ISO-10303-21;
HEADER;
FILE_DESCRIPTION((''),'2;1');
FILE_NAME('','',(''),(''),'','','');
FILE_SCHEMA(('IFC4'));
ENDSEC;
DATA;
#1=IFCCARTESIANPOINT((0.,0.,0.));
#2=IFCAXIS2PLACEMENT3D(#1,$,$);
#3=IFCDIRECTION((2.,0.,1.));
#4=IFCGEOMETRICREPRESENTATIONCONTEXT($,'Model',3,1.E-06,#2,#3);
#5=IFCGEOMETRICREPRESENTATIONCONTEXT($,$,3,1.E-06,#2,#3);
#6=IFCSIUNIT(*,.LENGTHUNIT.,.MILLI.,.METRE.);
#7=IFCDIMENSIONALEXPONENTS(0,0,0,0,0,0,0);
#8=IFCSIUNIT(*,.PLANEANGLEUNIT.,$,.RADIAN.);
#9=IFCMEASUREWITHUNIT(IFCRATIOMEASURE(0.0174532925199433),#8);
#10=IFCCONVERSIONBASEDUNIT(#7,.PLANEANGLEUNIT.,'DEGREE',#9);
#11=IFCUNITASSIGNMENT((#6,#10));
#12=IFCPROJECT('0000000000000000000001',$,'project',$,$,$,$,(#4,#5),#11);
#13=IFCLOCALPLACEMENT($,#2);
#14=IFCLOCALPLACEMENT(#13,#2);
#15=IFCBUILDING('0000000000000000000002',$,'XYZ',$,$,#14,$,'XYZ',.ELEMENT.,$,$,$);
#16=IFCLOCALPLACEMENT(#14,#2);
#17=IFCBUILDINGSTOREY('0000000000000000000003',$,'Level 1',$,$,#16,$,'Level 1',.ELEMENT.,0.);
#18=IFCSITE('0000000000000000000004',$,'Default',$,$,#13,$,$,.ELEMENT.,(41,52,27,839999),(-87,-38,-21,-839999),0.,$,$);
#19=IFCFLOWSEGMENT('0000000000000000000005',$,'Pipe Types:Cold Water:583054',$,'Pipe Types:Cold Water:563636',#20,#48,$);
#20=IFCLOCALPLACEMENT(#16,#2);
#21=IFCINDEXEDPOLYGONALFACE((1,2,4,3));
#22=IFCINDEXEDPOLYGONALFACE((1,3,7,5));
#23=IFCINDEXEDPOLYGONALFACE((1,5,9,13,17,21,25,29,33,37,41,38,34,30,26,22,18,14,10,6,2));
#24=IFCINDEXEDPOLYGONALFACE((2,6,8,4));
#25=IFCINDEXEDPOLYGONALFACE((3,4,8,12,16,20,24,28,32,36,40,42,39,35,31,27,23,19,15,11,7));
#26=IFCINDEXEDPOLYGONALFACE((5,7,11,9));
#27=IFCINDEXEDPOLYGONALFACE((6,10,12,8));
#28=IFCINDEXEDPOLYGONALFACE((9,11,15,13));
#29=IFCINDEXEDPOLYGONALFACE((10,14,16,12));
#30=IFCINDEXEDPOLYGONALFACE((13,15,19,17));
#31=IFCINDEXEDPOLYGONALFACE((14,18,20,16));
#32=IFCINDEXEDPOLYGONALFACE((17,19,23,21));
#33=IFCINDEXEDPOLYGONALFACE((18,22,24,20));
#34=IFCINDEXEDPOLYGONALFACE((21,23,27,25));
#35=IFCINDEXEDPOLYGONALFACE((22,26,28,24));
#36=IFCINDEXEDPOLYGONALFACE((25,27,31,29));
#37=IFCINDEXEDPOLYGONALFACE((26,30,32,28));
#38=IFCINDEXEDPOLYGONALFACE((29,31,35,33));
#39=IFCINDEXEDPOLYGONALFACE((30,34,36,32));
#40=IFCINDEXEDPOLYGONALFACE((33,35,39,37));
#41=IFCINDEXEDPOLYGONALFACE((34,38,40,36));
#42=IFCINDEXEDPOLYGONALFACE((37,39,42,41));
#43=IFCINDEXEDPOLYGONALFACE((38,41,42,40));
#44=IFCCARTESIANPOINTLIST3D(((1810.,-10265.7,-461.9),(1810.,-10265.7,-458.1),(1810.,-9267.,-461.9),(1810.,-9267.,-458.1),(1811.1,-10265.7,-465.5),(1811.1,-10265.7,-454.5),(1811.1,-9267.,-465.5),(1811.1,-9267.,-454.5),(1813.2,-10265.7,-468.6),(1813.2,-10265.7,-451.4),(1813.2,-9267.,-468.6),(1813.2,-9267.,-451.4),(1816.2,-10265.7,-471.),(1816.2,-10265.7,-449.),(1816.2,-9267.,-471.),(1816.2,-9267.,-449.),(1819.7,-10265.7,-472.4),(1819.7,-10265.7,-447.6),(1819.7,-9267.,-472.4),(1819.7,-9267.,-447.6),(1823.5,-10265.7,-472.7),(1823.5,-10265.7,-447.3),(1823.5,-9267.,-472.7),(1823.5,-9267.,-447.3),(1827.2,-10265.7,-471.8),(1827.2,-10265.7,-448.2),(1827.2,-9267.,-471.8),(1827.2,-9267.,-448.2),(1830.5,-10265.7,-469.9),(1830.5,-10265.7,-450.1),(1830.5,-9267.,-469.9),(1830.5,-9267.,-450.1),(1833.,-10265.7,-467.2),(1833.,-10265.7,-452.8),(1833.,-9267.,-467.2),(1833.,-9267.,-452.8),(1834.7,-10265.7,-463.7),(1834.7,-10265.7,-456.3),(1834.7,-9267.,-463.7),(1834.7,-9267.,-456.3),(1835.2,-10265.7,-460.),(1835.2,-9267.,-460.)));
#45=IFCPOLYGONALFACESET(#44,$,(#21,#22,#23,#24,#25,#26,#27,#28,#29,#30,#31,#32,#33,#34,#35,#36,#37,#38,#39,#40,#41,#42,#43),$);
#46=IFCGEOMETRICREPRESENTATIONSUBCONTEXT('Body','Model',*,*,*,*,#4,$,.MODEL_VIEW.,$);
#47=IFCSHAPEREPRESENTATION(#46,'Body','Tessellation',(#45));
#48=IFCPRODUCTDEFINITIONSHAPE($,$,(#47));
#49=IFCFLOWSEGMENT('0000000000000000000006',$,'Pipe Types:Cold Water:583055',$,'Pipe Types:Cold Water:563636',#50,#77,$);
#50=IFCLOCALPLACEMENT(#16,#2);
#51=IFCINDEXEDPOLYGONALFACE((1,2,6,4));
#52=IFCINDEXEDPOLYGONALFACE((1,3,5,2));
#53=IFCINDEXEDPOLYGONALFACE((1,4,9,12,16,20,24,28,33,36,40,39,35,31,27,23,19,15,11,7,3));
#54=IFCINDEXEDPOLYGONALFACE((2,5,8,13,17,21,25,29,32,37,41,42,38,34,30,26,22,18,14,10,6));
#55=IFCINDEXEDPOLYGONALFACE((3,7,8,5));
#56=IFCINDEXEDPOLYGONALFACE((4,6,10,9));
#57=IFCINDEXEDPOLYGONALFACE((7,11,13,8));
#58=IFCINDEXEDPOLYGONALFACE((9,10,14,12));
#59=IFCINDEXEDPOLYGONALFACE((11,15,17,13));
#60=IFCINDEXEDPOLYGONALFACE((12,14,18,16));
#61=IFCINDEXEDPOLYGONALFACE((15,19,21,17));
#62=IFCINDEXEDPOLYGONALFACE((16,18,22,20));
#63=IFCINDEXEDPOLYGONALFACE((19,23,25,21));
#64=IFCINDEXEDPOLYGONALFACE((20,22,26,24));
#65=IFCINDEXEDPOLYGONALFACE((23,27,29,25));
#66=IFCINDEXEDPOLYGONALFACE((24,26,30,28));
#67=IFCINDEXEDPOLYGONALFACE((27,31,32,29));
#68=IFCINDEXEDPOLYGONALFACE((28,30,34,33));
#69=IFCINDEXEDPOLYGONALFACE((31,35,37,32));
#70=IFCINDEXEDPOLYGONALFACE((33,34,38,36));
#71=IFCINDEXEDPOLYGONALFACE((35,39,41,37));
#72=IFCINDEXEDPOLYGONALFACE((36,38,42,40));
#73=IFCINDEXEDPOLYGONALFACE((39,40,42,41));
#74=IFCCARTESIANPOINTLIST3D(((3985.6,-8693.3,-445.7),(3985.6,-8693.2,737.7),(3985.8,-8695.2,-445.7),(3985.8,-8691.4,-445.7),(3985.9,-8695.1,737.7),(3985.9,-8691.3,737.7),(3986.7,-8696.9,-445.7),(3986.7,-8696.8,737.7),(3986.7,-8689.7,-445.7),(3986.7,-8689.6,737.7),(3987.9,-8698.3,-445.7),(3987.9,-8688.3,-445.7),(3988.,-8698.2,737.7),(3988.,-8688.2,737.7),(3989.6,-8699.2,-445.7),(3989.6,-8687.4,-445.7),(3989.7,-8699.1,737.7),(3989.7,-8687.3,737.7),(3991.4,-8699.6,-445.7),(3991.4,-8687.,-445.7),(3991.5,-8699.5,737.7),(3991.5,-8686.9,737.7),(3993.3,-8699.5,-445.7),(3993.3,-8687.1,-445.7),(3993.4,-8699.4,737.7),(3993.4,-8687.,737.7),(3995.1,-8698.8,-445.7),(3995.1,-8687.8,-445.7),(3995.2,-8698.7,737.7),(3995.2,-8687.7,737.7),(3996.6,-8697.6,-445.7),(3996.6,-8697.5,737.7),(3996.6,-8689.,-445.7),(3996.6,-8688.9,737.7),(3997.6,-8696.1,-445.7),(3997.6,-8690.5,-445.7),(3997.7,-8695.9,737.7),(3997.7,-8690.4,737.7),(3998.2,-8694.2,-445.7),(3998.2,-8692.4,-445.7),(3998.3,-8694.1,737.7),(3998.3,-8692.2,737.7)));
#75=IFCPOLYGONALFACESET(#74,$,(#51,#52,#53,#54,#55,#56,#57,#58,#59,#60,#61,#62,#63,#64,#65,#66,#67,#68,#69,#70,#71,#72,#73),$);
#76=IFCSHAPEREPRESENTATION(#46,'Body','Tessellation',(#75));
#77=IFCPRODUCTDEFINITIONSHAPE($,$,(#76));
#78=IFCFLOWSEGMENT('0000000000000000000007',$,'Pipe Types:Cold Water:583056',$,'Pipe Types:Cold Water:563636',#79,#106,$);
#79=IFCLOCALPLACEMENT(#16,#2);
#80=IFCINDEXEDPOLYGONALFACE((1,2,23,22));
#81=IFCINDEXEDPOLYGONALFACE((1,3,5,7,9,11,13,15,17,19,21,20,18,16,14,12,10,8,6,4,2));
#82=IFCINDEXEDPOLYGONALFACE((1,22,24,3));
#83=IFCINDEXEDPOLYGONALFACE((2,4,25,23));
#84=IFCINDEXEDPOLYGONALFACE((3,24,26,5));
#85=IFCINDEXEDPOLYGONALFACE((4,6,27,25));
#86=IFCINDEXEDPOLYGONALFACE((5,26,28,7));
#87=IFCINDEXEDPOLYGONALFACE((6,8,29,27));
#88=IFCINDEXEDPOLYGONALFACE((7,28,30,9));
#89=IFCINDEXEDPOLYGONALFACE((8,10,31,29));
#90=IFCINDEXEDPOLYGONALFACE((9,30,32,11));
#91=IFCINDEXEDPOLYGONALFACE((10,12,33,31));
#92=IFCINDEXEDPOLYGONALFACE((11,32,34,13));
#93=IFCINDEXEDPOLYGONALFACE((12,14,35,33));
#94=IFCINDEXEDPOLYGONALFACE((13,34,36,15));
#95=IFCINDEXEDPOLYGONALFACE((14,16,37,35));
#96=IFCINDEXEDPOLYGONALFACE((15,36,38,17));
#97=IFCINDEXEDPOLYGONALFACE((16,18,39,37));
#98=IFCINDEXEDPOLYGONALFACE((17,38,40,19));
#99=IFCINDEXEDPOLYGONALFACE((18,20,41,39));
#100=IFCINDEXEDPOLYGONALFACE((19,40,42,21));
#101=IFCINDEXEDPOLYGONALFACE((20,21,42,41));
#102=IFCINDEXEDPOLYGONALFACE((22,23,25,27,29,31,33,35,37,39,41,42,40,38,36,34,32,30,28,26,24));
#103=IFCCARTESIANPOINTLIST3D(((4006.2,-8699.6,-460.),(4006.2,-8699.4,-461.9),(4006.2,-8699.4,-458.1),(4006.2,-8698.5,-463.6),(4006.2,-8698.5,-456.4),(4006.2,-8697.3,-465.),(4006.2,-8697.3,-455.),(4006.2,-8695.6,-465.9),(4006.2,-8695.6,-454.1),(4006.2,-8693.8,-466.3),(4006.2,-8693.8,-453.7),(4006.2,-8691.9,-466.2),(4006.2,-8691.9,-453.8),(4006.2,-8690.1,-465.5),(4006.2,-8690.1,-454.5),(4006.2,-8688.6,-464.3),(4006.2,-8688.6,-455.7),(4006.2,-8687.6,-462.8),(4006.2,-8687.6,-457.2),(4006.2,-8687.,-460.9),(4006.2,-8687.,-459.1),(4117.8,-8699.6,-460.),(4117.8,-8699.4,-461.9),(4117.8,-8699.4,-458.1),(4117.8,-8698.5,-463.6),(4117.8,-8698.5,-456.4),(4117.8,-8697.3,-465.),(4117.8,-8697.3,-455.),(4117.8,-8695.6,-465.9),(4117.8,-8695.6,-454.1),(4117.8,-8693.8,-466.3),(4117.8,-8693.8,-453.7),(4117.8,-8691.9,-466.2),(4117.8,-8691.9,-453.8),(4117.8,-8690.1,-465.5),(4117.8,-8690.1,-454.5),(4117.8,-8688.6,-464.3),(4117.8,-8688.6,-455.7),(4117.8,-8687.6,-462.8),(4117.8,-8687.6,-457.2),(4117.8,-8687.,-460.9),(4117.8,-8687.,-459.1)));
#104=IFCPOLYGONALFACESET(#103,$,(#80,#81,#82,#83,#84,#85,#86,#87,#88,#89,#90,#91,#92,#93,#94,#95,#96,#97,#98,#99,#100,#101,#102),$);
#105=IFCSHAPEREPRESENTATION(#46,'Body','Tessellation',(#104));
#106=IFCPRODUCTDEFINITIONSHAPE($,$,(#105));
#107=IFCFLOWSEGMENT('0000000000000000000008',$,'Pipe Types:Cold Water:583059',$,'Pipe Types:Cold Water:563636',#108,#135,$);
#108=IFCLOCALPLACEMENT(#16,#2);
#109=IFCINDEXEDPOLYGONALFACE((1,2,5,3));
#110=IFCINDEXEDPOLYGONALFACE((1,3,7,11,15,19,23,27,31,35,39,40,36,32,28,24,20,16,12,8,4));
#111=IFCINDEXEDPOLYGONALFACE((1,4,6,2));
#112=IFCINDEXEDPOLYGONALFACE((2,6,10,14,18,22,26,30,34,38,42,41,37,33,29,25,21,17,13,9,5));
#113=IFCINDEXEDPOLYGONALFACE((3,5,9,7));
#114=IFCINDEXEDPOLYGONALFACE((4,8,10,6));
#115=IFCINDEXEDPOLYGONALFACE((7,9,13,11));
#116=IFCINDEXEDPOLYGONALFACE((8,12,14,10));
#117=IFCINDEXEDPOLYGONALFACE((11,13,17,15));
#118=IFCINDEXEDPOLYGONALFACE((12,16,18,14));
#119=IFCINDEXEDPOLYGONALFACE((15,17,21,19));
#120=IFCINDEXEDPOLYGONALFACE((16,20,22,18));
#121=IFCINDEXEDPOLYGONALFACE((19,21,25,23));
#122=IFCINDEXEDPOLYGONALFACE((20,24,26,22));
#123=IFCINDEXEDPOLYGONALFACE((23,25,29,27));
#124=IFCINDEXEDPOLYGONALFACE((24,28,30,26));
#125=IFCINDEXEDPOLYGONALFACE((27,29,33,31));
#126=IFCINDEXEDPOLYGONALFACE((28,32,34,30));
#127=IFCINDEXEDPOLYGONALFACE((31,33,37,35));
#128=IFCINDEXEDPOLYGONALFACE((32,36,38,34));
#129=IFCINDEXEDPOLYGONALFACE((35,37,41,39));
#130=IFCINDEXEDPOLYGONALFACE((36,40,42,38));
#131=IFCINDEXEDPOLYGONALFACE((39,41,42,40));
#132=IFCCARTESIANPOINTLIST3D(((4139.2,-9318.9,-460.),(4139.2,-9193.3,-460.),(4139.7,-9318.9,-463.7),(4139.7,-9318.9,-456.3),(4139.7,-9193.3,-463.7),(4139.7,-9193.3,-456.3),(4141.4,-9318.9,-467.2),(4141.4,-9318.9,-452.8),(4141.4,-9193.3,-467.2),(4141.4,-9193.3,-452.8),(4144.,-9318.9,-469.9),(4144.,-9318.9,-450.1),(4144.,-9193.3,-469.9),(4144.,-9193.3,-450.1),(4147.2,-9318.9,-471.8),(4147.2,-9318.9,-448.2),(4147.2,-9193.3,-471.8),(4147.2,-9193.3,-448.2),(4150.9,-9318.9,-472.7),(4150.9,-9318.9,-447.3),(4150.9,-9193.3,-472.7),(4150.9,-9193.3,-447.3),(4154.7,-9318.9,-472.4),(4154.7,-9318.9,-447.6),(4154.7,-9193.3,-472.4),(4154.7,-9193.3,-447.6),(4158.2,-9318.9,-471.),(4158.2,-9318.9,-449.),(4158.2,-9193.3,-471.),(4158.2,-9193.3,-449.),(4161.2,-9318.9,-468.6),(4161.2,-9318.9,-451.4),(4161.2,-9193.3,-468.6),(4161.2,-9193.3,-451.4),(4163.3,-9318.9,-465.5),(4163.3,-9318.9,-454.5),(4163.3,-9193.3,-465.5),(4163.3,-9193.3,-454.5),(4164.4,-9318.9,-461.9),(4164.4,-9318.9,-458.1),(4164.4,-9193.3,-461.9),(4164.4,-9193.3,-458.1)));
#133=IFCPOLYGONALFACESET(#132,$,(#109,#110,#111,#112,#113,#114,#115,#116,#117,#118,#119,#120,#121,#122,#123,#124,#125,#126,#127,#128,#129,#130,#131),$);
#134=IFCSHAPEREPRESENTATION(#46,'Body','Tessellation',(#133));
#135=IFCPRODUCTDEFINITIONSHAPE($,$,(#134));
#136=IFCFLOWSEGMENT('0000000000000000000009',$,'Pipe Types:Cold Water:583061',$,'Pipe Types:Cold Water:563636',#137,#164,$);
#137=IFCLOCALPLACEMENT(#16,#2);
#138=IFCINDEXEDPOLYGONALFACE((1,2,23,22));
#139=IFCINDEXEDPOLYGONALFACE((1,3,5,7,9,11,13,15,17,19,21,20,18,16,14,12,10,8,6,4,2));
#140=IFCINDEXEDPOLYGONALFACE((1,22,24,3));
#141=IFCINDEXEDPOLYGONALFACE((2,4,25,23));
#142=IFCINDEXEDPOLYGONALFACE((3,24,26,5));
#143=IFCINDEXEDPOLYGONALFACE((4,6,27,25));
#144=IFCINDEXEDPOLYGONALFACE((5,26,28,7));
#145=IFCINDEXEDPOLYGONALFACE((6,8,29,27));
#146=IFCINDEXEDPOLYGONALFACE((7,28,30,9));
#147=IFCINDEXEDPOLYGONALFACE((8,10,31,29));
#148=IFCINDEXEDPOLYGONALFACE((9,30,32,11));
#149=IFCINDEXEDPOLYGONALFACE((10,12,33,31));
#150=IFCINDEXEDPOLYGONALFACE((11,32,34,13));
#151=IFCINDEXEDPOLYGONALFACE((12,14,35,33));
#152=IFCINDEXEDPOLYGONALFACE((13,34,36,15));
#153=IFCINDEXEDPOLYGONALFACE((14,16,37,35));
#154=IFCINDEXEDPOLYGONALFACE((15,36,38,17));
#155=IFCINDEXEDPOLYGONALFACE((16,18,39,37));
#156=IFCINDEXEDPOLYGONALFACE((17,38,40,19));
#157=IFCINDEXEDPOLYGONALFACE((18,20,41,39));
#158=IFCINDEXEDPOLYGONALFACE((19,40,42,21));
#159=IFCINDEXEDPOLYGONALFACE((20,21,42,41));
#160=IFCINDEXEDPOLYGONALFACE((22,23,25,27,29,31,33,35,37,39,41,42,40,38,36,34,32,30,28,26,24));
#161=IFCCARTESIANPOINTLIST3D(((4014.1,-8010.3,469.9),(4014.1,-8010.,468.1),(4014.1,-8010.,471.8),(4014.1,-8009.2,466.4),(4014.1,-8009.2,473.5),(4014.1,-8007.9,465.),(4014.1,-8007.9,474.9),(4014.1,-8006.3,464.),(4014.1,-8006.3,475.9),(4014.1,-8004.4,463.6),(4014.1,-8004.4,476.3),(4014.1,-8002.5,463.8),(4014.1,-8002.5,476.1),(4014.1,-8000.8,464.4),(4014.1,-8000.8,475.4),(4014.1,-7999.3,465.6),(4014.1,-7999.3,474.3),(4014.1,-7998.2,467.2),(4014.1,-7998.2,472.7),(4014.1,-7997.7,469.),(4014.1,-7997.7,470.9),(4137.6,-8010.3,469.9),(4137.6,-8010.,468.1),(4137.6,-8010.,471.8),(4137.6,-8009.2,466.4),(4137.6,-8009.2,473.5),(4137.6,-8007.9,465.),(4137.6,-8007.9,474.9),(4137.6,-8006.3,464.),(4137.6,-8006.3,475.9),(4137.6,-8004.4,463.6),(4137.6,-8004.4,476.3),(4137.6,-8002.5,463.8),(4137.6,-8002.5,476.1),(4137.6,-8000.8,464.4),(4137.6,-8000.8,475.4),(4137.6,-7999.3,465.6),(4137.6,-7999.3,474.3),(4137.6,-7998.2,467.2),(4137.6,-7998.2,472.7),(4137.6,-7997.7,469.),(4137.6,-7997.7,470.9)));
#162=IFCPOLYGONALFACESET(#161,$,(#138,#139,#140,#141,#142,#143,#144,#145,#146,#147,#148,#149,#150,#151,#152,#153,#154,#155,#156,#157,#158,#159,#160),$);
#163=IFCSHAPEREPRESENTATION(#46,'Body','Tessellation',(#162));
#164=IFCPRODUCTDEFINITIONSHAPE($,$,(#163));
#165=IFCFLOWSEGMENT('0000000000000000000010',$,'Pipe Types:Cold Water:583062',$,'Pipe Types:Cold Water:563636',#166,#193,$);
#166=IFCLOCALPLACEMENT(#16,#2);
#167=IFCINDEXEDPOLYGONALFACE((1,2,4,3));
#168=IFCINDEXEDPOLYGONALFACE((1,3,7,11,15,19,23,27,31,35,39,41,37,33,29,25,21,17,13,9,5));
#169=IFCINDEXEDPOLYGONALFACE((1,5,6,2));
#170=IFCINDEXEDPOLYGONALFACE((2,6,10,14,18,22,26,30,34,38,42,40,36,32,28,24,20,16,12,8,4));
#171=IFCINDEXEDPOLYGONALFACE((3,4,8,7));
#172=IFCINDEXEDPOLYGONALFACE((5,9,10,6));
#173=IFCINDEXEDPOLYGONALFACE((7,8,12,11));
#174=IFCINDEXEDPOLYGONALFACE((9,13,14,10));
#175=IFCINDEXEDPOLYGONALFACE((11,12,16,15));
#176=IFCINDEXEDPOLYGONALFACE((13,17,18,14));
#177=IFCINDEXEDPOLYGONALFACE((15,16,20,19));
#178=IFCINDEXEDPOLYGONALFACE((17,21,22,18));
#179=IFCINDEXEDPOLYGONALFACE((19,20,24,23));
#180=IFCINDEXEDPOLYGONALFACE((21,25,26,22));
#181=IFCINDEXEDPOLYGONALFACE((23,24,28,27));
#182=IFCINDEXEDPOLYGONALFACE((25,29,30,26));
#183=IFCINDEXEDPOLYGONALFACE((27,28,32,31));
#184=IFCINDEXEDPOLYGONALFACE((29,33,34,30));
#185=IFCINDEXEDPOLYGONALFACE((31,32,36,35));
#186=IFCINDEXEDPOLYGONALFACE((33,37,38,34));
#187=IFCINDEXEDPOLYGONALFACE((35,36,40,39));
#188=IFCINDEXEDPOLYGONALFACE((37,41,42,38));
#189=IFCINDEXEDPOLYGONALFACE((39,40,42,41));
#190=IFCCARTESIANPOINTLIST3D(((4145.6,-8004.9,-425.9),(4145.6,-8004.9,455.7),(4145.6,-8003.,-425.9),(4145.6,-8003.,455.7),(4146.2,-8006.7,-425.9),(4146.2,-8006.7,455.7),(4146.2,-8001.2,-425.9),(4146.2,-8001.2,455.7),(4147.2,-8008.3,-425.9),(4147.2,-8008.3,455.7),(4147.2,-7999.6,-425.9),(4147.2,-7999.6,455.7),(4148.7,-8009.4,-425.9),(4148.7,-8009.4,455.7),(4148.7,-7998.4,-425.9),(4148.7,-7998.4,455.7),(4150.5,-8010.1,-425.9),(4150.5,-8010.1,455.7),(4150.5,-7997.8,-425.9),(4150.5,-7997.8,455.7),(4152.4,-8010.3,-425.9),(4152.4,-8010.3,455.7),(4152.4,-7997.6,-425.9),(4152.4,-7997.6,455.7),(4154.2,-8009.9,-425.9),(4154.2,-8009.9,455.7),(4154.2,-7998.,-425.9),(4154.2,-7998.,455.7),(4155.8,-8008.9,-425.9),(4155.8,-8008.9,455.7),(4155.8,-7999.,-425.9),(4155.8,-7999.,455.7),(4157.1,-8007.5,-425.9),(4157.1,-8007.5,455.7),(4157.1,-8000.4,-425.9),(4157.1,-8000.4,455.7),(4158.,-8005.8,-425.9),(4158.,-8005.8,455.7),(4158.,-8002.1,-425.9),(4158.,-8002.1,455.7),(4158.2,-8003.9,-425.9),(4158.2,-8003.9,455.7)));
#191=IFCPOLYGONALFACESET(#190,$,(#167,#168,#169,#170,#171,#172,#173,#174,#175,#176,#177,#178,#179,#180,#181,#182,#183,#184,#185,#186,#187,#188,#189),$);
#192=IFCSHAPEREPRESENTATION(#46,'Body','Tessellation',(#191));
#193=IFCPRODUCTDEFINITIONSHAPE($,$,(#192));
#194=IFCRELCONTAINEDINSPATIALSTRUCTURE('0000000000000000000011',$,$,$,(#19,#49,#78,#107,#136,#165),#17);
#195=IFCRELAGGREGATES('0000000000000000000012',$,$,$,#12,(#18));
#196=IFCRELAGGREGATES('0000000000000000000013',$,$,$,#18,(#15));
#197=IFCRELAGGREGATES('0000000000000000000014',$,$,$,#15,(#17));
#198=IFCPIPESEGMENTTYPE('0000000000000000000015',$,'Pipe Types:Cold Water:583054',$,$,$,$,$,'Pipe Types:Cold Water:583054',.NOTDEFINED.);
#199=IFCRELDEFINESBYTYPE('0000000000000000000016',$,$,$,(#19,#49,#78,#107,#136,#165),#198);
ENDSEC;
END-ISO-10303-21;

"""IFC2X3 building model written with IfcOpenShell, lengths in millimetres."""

from ifc_helpers import new_model, entity, si_unit, converted_unit, direction, frame, frame_2d, origin, origin_2d_with_axis, place, context, subcontext, project, spatial, circle, extrude, type_object, element, save


model = new_model("IFC2X3")

# Units and contexts
model_context = context("Model", 3, precision=1e-06, world=origin(), true_north=direction((2.0, 0.0, 1.0)))
context_of_model = context(None, 3, precision=1e-06, world=origin(), true_north=direction((2.0, 0.0, 1.0)))
body_context = subcontext(model_context, "Body", "Model", "MODEL_VIEW")
ifc_project = project(units=[si_unit("LENGTHUNIT", "METRE", prefix="MILLI"), converted_unit("PLANEANGLEUNIT", "DEGREE", entity("IfcRatioMeasure", 0.0174532925199433), si_unit("PLANEANGLEUNIT", "RADIAN"), dimensions=[0, 0, 0, 0, 0, 0, 0])], contexts=[model_context, context_of_model])

# Site, building, storey
site_placement = place(None, origin())
site = spatial("IfcSite", under=ifc_project, at=site_placement, Name="Default", CompositionType="ELEMENT", RefLatitude=(41, 52, 27, 839999), RefLongitude=(-87, -38, -21, -839999), RefElevation=0.0)
building_placement = place(site_placement, origin())
building = spatial("IfcBuilding", under=site, at=building_placement, Name="XYZ", LongName="XYZ", CompositionType="ELEMENT")
storey_placement = place(building_placement, origin())
storey = spatial("IfcBuildingStorey", under=building, at=storey_placement, Name="Level 1", LongName="Level 1", CompositionType="ELEMENT", Elevation=0.0)

# Flow segments
pipe_segment_type_1 = type_object("IfcPipeSegmentType", Name="Pipe Types:Cold Water:583054", ElementType="Pipe Types:Cold Water:583054", PredefinedType="NOTDEFINED")
flow_segment_1_placement = place(storey_placement, origin())
element("IfcFlowSegment", 1, at=flow_segment_1_placement, inside=storey, type_object=pipe_segment_type_1, Name="Pipe Types:Cold Water:583054", ObjectType="Pipe Types:Cold Water:563636", context=body_context, shape_type="SweptSolid", body=[
    extrude(circle(Radius=12.7, at=origin_2d_with_axis()), frame((1822.5, -10265.7, -460.0), z_axis=(0.0, 1.0, 0.0), x_axis=(1.0, 0.0, 0.0)), (0.0, 0.0, 1.0), 998.7),
])
flow_segment_2_placement = place(storey_placement, origin())
element("IfcFlowSegment", 2, at=flow_segment_2_placement, inside=storey, type_object=pipe_segment_type_1, Name="Pipe Types:Cold Water:583055", ObjectType="Pipe Types:Cold Water:563636", context=body_context, shape_type="SweptSolid", body=[
    extrude(circle(Radius=6.3, at=frame_2d((0.0, 0.0), x_axis=(1.0, 0.0))), frame((3991.9, -8693.3, -445.7), z_axis=(0.000073, 0.000088, 1.0), x_axis=(-1.0, 0.0, 0.000073)), (0.0, 0.0, 1.0), 1183.4),
])
flow_segment_3_placement = place(storey_placement, origin())
element("IfcFlowSegment", 3, at=flow_segment_3_placement, inside=storey, type_object=pipe_segment_type_1, Name="Pipe Types:Cold Water:583056", ObjectType="Pipe Types:Cold Water:563636", context=body_context, shape_type="SweptSolid", body=[
    extrude(circle(Radius=6.3, at=origin_2d_with_axis()), frame((4006.2, -8693.3, -460.0), z_axis=(1.0, 0.0, 0.0), x_axis=(0.0, -1.0, 0.0)), (0.0, 0.0, 1.0), 111.6),
])
flow_segment_4_placement = place(storey_placement, origin())
element("IfcFlowSegment", 4, at=flow_segment_4_placement, inside=storey, type_object=pipe_segment_type_1, Name="Pipe Types:Cold Water:583059", ObjectType="Pipe Types:Cold Water:563636", context=body_context, shape_type="SweptSolid", body=[
    extrude(circle(Radius=12.7, at=frame_2d((0.0, 0.0), x_axis=(1.0, 0.0))), frame((4151.9, -9318.9, -460.0), z_axis=(0.0, 1.0, 0.0), x_axis=(-1.0, 0.0, 0.0)), (0.0, 0.0, 1.0), 125.5),
])
flow_segment_5_placement = place(storey_placement, origin())
element("IfcFlowSegment", 5, at=flow_segment_5_placement, inside=storey, type_object=pipe_segment_type_1, Name="Pipe Types:Cold Water:583061", ObjectType="Pipe Types:Cold Water:563636", context=body_context, shape_type="SweptSolid", body=[
    extrude(circle(Radius=6.3, at=frame_2d((0.0, 0.0), x_axis=(1.0, 0.0))), frame((4014.1, -8003.9, 469.9), z_axis=(1.0, 0.0, 0.0), x_axis=(0.0, -1.0, 0.0)), (0.0, 0.0, 1.0), 123.5),
])
flow_segment_6_placement = place(storey_placement, origin())
element("IfcFlowSegment", 6, at=flow_segment_6_placement, inside=storey, type_object=pipe_segment_type_1, Name="Pipe Types:Cold Water:583062", ObjectType="Pipe Types:Cold Water:563636", context=body_context, shape_type="SweptSolid", body=[
    extrude(circle(Radius=6.3, at=frame_2d((0.0, 0.0), x_axis=(1.0, 0.0))), frame((4151.9, -8003.9, -425.9)), (0.0, 0.0, 1.0), 881.5),
])

save(model, "model.ifc")
